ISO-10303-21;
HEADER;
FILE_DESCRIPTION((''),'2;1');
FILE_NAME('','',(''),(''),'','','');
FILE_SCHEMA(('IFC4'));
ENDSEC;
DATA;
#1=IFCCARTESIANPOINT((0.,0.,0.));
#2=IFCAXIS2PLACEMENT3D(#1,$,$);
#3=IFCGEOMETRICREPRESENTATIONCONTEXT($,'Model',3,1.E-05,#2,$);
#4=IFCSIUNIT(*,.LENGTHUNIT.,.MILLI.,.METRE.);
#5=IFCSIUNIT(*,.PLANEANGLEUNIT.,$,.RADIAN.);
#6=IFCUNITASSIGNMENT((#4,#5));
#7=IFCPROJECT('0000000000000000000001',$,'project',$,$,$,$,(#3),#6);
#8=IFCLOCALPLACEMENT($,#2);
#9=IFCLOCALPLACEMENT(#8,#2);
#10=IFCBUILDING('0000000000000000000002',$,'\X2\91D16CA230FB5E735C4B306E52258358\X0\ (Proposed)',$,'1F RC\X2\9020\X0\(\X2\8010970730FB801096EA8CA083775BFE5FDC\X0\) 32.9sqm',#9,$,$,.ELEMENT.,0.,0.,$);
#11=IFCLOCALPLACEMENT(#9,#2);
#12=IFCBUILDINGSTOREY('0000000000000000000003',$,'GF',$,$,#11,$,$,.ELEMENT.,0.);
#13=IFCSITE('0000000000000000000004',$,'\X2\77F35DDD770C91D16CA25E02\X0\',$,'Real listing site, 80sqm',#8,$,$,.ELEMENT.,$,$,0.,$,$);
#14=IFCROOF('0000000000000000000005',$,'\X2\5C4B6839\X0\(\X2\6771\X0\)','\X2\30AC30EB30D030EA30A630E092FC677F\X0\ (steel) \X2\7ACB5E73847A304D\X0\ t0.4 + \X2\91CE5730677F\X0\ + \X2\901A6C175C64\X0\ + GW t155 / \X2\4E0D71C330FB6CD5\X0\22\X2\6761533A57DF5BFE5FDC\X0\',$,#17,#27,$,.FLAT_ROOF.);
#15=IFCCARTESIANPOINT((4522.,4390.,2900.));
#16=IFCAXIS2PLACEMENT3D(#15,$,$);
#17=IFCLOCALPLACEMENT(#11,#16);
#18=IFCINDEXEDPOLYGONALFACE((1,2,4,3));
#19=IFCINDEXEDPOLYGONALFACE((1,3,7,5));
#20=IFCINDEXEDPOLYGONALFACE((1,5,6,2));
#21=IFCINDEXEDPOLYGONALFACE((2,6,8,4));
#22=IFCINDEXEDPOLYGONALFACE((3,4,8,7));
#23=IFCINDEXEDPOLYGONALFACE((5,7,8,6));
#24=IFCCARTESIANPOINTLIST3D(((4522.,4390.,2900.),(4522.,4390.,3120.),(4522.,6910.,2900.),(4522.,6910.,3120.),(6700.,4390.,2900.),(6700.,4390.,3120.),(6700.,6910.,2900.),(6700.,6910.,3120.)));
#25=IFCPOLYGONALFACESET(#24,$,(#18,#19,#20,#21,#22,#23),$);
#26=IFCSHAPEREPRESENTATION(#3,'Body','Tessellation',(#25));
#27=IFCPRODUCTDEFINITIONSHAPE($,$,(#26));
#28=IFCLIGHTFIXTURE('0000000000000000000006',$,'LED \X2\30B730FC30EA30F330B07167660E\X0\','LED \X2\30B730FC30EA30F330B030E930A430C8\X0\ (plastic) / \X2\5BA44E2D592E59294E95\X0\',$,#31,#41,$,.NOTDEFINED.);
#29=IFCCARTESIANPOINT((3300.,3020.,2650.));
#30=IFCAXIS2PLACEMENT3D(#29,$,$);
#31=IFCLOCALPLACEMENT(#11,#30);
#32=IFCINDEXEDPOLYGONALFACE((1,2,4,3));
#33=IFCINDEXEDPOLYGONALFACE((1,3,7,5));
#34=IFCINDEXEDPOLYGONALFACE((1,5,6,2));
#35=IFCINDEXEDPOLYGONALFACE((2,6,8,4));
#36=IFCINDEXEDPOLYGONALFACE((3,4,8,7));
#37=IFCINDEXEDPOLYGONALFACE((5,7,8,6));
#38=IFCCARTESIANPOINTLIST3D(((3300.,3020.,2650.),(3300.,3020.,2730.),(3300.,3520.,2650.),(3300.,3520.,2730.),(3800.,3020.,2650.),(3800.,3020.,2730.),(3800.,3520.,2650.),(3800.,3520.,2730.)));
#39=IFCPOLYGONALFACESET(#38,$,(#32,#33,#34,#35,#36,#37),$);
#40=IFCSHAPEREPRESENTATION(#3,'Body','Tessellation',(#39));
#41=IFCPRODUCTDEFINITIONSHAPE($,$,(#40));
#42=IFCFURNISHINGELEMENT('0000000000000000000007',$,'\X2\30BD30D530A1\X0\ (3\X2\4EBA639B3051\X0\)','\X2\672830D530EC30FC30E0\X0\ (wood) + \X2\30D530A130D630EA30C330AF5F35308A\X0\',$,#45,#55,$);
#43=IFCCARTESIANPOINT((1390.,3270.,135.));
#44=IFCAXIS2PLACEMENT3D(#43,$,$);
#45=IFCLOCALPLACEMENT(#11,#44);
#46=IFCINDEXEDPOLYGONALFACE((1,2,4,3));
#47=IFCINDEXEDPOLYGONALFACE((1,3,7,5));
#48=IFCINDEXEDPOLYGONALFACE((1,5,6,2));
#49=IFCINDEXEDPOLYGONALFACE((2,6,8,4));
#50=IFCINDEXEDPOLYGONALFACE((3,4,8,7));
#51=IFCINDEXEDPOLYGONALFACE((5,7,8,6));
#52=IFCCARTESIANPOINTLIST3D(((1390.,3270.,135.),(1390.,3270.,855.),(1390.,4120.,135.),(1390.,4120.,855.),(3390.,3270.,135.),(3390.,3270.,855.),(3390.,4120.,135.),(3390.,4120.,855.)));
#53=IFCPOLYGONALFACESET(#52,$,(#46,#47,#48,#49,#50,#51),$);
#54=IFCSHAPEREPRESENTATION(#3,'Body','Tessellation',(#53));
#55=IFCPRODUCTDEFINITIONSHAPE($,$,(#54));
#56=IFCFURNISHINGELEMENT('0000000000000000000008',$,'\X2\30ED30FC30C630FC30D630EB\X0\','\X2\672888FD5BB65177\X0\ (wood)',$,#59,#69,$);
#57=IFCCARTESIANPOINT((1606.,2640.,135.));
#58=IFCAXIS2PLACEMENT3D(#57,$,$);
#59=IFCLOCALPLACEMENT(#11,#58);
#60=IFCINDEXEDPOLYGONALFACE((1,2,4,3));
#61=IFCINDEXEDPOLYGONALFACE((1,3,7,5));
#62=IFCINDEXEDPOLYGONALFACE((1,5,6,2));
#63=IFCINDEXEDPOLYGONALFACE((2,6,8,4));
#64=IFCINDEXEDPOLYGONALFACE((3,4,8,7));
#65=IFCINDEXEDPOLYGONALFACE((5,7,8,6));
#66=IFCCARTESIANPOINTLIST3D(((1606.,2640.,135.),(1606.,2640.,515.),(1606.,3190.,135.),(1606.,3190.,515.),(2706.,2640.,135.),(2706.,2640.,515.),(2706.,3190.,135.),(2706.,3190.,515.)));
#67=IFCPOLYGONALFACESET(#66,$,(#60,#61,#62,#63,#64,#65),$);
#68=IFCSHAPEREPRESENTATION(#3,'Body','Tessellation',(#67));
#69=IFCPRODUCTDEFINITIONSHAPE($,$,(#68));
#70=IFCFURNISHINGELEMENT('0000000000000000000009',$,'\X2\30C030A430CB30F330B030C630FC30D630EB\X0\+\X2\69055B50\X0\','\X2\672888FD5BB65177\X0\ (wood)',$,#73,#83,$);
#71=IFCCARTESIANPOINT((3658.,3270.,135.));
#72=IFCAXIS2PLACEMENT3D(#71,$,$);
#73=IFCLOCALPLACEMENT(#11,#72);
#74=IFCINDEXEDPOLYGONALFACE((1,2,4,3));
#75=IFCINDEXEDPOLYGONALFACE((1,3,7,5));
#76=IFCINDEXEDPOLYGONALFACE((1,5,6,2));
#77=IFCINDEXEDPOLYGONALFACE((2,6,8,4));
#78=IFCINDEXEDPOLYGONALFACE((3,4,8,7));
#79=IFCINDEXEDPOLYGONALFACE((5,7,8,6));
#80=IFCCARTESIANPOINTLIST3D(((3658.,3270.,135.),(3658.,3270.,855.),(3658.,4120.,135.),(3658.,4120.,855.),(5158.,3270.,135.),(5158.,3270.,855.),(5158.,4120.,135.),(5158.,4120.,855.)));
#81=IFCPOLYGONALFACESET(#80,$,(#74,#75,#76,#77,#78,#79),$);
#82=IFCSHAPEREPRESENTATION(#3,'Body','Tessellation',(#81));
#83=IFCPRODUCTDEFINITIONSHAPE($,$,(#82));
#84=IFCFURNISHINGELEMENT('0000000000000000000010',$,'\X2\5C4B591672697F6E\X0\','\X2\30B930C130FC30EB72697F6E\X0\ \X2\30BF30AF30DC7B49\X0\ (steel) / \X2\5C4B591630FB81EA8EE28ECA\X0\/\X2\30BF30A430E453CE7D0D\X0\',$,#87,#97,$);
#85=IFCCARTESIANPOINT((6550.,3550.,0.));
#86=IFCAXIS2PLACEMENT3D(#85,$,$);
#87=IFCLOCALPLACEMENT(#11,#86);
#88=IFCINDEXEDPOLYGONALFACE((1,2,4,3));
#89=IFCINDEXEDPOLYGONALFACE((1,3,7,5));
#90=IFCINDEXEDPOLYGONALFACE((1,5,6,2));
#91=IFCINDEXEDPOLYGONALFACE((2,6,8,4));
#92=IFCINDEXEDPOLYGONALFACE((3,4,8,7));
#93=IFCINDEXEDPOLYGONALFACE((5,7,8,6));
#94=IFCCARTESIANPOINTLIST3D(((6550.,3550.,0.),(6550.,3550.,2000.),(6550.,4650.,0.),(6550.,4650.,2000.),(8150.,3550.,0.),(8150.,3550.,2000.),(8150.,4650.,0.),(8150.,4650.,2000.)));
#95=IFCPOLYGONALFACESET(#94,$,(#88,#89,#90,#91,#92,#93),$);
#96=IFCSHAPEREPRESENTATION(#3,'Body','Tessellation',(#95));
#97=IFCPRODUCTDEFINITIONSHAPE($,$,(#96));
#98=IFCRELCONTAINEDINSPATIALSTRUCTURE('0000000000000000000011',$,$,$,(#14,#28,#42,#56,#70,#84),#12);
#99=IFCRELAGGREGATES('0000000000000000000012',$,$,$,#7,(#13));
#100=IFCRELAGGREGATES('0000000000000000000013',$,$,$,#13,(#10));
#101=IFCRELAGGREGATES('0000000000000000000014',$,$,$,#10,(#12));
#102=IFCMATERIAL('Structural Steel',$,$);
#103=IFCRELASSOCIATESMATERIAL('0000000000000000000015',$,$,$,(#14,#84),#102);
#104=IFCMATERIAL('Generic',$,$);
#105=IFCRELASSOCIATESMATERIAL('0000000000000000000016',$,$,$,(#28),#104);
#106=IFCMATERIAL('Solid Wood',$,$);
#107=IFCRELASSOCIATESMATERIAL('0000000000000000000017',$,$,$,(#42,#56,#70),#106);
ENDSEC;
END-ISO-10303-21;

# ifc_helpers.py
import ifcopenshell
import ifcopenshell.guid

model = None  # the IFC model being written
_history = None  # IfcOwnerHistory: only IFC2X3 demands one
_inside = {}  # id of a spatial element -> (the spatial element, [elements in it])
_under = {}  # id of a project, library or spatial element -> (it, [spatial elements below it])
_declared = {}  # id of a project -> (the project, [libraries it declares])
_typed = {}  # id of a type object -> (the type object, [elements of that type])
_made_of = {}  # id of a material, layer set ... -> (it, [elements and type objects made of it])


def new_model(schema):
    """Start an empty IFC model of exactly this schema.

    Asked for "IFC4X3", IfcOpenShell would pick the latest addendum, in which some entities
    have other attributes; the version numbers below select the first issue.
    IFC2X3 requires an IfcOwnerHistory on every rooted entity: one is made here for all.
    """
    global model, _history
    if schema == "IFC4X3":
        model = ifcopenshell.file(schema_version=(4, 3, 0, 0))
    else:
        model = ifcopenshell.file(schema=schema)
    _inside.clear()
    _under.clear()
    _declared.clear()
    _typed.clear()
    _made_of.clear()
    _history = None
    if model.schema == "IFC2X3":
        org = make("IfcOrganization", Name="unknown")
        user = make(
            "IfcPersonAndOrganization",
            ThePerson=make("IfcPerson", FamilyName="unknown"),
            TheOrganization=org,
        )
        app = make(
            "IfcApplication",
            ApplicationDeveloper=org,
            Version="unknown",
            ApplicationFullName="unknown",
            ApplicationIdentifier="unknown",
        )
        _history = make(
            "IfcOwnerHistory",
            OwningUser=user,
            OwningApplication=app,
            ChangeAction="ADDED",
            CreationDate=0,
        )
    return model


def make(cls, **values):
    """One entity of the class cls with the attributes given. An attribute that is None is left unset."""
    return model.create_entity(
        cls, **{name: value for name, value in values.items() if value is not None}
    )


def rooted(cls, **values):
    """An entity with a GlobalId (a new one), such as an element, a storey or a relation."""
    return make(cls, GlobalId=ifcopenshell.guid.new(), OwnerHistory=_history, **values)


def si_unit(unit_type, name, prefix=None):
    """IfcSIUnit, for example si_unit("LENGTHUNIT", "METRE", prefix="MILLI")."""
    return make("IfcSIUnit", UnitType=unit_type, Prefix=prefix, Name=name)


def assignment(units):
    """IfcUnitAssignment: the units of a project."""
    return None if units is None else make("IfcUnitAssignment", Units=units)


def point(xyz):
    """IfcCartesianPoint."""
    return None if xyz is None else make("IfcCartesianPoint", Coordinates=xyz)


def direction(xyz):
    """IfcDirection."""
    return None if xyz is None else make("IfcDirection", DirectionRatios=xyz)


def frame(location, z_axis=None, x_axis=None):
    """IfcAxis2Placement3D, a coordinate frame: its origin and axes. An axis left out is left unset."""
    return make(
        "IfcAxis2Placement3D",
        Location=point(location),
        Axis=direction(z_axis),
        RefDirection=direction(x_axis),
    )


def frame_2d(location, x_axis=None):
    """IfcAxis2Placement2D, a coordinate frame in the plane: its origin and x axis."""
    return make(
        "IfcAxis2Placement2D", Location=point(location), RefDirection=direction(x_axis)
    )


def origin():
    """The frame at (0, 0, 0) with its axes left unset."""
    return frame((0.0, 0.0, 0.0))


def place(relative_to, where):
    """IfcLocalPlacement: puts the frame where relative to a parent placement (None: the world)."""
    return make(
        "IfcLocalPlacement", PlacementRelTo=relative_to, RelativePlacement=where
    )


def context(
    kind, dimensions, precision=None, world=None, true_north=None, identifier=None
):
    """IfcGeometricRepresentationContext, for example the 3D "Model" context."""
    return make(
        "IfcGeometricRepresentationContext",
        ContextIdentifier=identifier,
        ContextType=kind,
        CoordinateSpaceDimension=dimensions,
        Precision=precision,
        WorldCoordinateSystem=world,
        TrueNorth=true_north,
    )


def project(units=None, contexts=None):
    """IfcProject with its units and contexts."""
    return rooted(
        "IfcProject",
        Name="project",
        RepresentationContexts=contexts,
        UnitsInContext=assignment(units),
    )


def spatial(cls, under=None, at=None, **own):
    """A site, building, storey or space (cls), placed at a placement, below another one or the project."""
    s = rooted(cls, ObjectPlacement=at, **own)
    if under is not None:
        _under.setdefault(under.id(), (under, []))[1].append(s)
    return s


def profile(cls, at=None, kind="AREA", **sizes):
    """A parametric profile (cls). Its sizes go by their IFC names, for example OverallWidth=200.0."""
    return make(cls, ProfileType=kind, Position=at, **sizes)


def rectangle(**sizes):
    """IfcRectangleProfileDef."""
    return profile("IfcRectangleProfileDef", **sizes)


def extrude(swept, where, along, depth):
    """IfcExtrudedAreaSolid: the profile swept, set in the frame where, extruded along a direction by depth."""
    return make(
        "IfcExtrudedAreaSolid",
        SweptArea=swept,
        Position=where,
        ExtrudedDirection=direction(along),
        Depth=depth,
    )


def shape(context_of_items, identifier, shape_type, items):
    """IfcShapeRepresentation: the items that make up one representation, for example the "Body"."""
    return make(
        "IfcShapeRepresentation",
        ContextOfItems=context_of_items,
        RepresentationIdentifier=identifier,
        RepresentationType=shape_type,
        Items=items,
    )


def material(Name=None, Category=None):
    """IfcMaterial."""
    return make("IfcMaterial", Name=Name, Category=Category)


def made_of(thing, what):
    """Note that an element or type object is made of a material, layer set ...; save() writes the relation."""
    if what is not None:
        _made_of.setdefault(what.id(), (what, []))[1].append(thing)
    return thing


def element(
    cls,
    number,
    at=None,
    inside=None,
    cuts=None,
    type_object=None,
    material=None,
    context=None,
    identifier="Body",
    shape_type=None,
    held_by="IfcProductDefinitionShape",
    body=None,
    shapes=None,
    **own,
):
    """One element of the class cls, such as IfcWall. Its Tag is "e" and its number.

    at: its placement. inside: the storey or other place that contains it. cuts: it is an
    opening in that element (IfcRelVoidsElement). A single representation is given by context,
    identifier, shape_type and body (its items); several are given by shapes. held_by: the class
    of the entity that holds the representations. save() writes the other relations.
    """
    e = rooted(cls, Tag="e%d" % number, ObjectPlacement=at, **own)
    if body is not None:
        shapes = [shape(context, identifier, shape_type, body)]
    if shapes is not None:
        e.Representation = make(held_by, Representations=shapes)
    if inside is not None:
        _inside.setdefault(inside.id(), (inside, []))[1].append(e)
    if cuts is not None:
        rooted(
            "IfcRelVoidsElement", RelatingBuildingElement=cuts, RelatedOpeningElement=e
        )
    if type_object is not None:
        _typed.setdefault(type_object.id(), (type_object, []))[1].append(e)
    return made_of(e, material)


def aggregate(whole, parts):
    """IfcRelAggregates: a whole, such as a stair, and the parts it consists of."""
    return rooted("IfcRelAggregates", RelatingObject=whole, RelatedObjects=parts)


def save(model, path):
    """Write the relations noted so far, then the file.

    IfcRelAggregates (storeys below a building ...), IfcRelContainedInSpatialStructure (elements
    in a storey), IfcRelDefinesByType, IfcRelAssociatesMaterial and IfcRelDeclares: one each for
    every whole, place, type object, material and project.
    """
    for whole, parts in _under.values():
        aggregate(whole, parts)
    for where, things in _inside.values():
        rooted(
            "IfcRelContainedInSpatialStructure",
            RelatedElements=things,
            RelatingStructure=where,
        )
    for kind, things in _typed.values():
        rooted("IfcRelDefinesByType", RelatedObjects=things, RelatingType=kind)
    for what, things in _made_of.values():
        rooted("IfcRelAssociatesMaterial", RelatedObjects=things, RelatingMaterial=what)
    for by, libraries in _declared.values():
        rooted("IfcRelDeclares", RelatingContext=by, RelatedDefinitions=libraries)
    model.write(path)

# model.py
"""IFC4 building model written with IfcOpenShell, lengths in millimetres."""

from ifc_helpers import new_model, si_unit, frame, frame_2d, origin, place, context, project, spatial, rectangle, extrude, material, element, save


model = new_model("IFC4")

# Units and contexts
model_context = context("Model", 3, precision=1e-05, world=origin())
ifc_project = project(units=[si_unit("LENGTHUNIT", "METRE", prefix="MILLI"), si_unit("PLANEANGLEUNIT", "RADIAN")], contexts=[model_context])

# Site, building, storey
site_placement = place(None, origin())
site = spatial("IfcSite", under=ifc_project, at=site_placement, Name="石川県金沢市", ObjectType="Real listing site, 80sqm", CompositionType="ELEMENT", RefElevation=0.0)
building_placement = place(site_placement, origin())
building = spatial("IfcBuilding", under=site, at=building_placement, Name="金沢・平屋の別荘 (Proposed)", ObjectType="1F RC造(耐震・耐雪負荷対応) 32.9sqm", CompositionType="ELEMENT", ElevationOfRefHeight=0.0, ElevationOfTerrain=0.0)
storey_placement = place(building_placement, origin())
storey = spatial("IfcBuildingStorey", under=building, at=storey_placement, Name="GF", CompositionType="ELEMENT", Elevation=0.0)

# Shared definitions
ifc_material_1 = material(Name="Solid Wood")

# Roof
ifc_material_2 = material(Name="Structural Steel")
roof_1_placement = place(storey_placement, frame((4522.0, 4390.0, 2900.0)))
element("IfcRoof", 1, at=roof_1_placement, inside=storey, material=ifc_material_2, Name="屋根(東)", Description="ガルバリウム鋼板 (steel) 立平葺き t0.4 + 野地板 + 通気層 + GW t155 / 不燃・法22条区域対応", PredefinedType="FLAT_ROOF", context=model_context, shape_type="SweptSolid", body=[
    extrude(rectangle(XDim=2178.0, YDim=2520.0, at=frame_2d((1089.0, 1260.0))), frame((4522.0, 4390.0, 2900.0)), (0.0, 0.0, 1.0), 220.0),
])

# Light fixture
ifc_material_3 = material(Name="Generic")
light_fixture_placement = place(storey_placement, frame((3300.0, 3020.0, 2650.0)))
element("IfcLightFixture", 2, at=light_fixture_placement, inside=storey, material=ifc_material_3, Name="LED シーリング照明", Description="LED シーリングライト (plastic) / 室中央天井", PredefinedType="NOTDEFINED", context=model_context, shape_type="SweptSolid", body=[
    extrude(rectangle(XDim=500.0, YDim=500.0, at=frame_2d((250.0, 250.0))), frame((3300.0, 3020.0, 2650.0)), (0.0, 0.0, 1.0), 80.0),
])

# Furnishing elements
furnishing_1_placement = place(storey_placement, frame((1390.0, 3270.0, 135.0)))
element("IfcFurnishingElement", 3, at=furnishing_1_placement, inside=storey, material=ifc_material_1, Name="ソファ (3人掛け)", Description="木フレーム (wood) + ファブリック張り", context=model_context, shape_type="SweptSolid", body=[
    extrude(rectangle(XDim=2000.0, YDim=850.0, at=frame_2d((1000.0, 425.0))), frame((1390.0, 3270.0, 135.0)), (0.0, 0.0, 1.0), 720.0),
])
furnishing_2_placement = place(storey_placement, frame((1606.0, 2640.0, 135.0)))
element("IfcFurnishingElement", 4, at=furnishing_2_placement, inside=storey, material=ifc_material_1, Name="ローテーブル", Description="木製家具 (wood)", context=model_context, shape_type="SweptSolid", body=[
    extrude(rectangle(XDim=1100.0, YDim=550.0, at=frame_2d((550.0, 275.0))), frame((1606.0, 2640.0, 135.0)), (0.0, 0.0, 1.0), 380.0),
])
furnishing_3_placement = place(storey_placement, frame((3658.0, 3270.0, 135.0)))
element("IfcFurnishingElement", 5, at=furnishing_3_placement, inside=storey, material=ifc_material_1, Name="ダイニングテーブル+椅子", Description="木製家具 (wood)", context=model_context, shape_type="SweptSolid", body=[
    extrude(rectangle(XDim=1500.0, YDim=850.0, at=frame_2d((750.0, 425.0))), frame((3658.0, 3270.0, 135.0)), (0.0, 0.0, 1.0), 720.0),
])
furnishing_4_placement = place(storey_placement, frame((6550.0, 3550.0, 0.0)))
element("IfcFurnishingElement", 6, at=furnishing_4_placement, inside=storey, material=ifc_material_2, Name="屋外物置", Description="スチール物置 タクボ等 (steel) / 屋外・自転車/タイヤ収納", context=model_context, shape_type="SweptSolid", body=[
    extrude(rectangle(XDim=1600.0, YDim=1100.0, at=frame_2d((800.0, 550.0))), frame((6550.0, 3550.0, 0.0)), (0.0, 0.0, 1.0), 2000.0),
])

save(model, "model.ifc")
